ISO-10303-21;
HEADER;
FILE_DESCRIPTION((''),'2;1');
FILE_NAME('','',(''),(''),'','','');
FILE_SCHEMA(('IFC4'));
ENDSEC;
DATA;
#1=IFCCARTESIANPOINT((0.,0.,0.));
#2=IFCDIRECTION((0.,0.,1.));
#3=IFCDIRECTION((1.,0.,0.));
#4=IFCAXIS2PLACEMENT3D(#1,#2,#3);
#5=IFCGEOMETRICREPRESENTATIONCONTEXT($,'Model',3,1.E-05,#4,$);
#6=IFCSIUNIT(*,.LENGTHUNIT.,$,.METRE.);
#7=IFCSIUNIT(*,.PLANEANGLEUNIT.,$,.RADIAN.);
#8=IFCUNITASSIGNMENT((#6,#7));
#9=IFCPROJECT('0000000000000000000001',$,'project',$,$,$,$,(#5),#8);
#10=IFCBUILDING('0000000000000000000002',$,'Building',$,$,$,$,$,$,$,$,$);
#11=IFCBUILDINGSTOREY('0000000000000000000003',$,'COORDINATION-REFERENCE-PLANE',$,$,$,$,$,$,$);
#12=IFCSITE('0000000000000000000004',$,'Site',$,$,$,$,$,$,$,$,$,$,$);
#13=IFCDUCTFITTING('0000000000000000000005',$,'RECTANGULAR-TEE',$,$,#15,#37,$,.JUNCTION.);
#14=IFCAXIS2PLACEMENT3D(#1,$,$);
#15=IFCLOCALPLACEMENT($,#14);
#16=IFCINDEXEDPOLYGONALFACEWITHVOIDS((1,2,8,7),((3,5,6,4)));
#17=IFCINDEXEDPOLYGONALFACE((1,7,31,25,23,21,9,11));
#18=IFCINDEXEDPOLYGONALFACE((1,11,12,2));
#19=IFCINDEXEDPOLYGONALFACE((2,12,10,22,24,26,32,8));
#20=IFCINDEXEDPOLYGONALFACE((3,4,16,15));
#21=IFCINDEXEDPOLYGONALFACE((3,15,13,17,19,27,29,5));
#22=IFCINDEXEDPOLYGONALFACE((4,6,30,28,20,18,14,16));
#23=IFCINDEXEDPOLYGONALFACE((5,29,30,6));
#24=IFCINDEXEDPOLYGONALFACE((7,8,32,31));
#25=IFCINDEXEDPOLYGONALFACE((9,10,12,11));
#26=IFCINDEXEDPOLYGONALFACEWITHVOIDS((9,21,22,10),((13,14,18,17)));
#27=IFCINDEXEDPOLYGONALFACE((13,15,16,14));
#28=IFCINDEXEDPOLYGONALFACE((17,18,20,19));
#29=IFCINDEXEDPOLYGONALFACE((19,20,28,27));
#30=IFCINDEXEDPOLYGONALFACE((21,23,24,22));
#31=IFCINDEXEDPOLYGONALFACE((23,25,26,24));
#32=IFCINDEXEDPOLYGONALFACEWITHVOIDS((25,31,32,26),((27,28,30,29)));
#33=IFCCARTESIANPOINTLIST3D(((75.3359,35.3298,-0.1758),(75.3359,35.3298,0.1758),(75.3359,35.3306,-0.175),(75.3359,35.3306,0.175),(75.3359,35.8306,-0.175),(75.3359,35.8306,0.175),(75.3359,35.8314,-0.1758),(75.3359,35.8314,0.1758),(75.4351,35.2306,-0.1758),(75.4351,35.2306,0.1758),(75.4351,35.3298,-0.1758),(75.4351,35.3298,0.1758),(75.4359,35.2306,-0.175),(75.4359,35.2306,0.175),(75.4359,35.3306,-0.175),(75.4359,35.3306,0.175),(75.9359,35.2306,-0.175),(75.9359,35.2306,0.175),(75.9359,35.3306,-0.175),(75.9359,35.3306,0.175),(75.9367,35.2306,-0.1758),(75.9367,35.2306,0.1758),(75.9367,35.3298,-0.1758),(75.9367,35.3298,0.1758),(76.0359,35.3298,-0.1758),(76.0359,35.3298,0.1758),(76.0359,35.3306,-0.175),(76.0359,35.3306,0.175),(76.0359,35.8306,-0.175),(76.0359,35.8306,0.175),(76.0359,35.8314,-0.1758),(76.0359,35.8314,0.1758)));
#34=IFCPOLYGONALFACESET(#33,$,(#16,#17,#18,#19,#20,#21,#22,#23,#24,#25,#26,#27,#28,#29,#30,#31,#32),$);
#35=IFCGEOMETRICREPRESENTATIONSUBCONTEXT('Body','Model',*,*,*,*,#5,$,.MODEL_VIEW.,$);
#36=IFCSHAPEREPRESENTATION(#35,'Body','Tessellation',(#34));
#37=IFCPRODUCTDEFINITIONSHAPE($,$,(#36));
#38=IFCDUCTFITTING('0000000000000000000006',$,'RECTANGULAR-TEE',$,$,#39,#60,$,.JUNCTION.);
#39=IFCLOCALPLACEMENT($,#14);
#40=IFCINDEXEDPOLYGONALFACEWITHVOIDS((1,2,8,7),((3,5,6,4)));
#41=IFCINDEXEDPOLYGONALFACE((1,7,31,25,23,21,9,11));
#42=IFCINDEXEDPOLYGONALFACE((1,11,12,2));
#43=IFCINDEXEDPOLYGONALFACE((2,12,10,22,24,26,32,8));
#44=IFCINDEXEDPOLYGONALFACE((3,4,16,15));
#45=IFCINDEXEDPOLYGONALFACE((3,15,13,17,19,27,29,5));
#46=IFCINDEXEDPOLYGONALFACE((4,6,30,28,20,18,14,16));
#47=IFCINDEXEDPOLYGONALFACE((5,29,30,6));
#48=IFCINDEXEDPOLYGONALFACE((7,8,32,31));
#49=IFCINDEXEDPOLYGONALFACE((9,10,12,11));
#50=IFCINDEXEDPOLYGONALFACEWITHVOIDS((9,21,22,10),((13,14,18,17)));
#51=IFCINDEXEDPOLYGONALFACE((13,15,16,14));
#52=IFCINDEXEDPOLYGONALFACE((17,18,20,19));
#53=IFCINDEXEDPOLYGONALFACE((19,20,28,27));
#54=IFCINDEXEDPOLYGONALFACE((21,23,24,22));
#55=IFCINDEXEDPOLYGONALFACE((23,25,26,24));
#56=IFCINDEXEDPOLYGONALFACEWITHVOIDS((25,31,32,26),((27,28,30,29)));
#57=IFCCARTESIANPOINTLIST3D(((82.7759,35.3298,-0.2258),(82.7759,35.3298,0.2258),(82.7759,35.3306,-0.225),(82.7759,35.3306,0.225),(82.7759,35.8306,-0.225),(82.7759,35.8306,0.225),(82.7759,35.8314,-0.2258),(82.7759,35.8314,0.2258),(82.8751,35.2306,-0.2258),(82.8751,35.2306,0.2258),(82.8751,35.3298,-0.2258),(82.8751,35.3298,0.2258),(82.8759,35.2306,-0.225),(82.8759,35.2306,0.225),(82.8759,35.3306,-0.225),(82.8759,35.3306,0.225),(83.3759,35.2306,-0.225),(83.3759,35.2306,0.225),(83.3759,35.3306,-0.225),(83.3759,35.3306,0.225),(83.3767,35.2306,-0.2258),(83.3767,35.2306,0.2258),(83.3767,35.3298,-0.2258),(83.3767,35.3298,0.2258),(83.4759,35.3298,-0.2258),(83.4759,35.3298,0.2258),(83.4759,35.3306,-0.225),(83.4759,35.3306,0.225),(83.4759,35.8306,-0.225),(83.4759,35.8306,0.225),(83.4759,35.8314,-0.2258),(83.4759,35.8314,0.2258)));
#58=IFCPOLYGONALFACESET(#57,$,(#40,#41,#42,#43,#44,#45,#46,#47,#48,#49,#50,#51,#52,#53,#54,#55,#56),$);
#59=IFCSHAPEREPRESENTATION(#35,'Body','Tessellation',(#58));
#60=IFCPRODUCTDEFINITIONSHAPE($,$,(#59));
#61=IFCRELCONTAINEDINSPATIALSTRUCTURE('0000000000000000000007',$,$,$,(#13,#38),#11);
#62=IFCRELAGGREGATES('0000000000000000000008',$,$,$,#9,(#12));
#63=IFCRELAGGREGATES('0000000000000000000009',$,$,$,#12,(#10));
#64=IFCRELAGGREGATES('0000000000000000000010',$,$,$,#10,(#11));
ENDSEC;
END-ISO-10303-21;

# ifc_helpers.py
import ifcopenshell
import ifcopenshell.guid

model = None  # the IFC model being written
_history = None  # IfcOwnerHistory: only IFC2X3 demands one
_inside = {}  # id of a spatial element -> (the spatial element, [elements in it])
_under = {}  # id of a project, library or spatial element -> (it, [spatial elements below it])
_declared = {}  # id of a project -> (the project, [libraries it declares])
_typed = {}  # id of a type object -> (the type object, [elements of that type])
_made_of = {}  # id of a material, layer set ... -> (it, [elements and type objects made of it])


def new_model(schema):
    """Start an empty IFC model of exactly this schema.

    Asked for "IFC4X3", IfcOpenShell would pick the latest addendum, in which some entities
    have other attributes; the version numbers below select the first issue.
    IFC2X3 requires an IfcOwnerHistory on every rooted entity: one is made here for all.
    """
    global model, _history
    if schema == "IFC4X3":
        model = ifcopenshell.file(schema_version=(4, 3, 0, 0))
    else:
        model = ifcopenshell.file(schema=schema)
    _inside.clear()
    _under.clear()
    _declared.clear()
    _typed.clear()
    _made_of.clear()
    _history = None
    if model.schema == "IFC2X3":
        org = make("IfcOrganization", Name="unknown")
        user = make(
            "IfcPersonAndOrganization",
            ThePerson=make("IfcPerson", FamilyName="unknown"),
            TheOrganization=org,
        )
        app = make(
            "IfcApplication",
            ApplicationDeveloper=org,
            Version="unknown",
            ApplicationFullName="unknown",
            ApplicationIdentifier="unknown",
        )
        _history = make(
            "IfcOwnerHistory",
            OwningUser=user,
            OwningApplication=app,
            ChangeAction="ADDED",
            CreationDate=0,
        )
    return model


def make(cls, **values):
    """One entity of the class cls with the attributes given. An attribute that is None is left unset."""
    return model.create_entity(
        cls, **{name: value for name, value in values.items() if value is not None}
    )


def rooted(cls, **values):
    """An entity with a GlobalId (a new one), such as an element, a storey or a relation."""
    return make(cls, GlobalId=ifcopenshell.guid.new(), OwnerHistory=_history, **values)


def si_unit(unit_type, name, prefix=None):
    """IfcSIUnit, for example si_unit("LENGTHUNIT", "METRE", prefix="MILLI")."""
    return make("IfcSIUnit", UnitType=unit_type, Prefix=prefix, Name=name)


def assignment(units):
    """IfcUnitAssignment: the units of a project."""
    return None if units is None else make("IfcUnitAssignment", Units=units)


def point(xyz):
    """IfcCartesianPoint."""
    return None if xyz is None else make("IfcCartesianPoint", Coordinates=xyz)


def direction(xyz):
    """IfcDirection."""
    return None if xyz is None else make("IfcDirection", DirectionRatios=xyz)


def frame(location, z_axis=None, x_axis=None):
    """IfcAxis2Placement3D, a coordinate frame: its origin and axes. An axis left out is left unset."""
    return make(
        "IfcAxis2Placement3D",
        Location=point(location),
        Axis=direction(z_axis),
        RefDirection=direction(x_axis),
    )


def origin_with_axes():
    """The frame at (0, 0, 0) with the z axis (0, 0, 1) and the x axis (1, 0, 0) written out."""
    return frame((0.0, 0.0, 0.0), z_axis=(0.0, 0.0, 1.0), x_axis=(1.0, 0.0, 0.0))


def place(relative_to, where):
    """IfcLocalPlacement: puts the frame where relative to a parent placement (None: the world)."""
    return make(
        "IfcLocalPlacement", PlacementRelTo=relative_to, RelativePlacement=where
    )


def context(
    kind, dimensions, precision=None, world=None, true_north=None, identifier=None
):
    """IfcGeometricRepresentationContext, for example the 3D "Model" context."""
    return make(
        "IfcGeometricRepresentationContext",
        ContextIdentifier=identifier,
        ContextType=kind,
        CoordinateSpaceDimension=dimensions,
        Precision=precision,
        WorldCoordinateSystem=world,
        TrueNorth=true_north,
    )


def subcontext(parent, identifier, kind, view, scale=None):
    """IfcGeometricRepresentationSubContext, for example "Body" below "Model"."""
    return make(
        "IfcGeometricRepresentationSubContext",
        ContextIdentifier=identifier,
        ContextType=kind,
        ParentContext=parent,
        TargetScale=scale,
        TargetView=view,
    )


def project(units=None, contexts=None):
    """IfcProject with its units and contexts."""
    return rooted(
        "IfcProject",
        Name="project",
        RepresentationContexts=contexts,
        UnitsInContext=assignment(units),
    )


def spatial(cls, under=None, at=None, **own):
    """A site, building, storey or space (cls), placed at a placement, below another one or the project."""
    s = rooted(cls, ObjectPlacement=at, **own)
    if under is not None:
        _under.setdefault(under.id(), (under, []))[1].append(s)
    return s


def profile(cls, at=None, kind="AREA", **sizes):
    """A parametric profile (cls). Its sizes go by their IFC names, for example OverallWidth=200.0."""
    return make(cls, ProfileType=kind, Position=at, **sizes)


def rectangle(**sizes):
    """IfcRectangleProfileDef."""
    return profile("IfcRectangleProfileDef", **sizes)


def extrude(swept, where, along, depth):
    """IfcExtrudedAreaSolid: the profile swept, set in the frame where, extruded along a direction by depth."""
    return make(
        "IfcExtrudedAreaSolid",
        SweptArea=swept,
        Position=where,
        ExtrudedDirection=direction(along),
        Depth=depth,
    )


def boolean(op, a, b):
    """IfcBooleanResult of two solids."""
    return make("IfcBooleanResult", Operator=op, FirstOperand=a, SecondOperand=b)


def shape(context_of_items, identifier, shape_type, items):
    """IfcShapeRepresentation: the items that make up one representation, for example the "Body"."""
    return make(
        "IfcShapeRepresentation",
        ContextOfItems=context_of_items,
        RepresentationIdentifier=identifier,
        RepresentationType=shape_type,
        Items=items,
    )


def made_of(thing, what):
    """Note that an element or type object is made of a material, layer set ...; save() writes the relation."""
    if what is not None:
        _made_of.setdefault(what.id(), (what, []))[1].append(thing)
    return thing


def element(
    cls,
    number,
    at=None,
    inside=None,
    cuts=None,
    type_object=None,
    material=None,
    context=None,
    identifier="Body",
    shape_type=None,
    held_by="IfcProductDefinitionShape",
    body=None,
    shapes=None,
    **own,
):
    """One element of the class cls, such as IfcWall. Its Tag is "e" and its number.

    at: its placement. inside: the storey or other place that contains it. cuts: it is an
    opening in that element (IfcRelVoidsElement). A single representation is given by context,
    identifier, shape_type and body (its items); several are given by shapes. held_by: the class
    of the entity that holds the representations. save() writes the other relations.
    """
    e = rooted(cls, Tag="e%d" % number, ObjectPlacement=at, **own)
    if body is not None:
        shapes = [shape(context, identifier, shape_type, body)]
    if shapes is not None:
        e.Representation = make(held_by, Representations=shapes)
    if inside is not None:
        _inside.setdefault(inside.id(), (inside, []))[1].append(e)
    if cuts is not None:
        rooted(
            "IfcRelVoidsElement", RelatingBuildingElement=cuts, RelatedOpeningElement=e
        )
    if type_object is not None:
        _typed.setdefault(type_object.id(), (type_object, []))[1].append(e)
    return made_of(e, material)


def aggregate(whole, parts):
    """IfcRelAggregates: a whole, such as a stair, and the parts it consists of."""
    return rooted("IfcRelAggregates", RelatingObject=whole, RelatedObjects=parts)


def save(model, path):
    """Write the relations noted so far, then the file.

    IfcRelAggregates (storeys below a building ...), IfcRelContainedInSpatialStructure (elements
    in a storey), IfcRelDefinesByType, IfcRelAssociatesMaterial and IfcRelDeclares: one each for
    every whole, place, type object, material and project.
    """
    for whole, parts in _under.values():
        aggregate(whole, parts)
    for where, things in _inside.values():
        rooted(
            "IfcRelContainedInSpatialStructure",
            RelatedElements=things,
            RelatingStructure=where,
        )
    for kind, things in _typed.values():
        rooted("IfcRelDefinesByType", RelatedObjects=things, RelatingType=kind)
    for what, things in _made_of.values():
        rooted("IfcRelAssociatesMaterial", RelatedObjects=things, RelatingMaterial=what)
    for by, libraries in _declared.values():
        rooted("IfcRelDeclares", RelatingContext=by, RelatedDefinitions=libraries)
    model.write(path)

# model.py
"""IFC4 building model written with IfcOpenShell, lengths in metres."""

from ifc_helpers import new_model, si_unit, frame, origin_with_axes, place, context, subcontext, project, spatial, rectangle, extrude, boolean, element, save


model = new_model("IFC4")

# Units and contexts
model_context = context("Model", 3, precision=1e-05, world=origin_with_axes())
body_context = subcontext(model_context, "Body", "Model", "MODEL_VIEW")
ifc_project = project(units=[si_unit("LENGTHUNIT", "METRE"), si_unit("PLANEANGLEUNIT", "RADIAN")], contexts=[model_context])

# Site, building, storey
site = spatial("IfcSite", under=ifc_project, Name="Site")
building = spatial("IfcBuilding", under=site, Name="Building")
storey = spatial("IfcBuildingStorey", under=building, Name="COORDINATION-REFERENCE-PLANE")

# Duct fittings
duct_fitting_1_placement = place(None, frame((75.6859, 35.5806, 0.0), z_axis=(-1.0, 0.0, 0.0), x_axis=(0.0, -1.0, 0.0)))
solid_1 = boolean("UNION", extrude(rectangle(XDim=0.5, YDim=0.35), frame((0.0, 0.0, -0.35), z_axis=(0.0, 0.0, 1.0), x_axis=(1.0, 0.0, 0.0)), (0.0, 0.0, 1.0), 0.7), extrude(rectangle(XDim=0.5, YDim=0.35), frame((0.0, 0.0, 0.0), z_axis=(1.0, 0.0, 0.0), x_axis=(0.0, 0.0, -1.0)), (0.0, 0.0, 1.0), 0.35))
element("IfcDuctFitting", 1, at=duct_fitting_1_placement, inside=storey, Name="RECTANGULAR-TEE", PredefinedType="JUNCTION", context=body_context, shape_type="CSG", body=[
    boolean("DIFFERENCE", boolean("UNION", extrude(rectangle(XDim=0.5016, YDim=0.3516), frame((0.0, 0.0, -0.35), z_axis=(0.0, 0.0, 1.0), x_axis=(1.0, 0.0, 0.0)), (0.0, 0.0, 1.0), 0.7), extrude(rectangle(XDim=0.5016, YDim=0.3516), frame((0.0, 0.0, 0.0), z_axis=(1.0, 0.0, 0.0), x_axis=(0.0, 0.0, -1.0)), (0.0, 0.0, 1.0), 0.35)), solid_1),
])
duct_fitting_2_placement = place(None, frame((83.1259, 35.5806, 0.0), z_axis=(-1.0, 0.0, 0.0), x_axis=(0.0, -1.0, 0.0)))
solid_2 = boolean("UNION", extrude(rectangle(XDim=0.5, YDim=0.45), frame((0.0, 0.0, -0.35), z_axis=(0.0, 0.0, 1.0), x_axis=(1.0, 0.0, 0.0)), (0.0, 0.0, 1.0), 0.7), extrude(rectangle(XDim=0.5, YDim=0.45), frame((0.0, 0.0, 0.0), z_axis=(1.0, 0.0, 0.0), x_axis=(0.0, 0.0, -1.0)), (0.0, 0.0, 1.0), 0.35))
element("IfcDuctFitting", 2, at=duct_fitting_2_placement, inside=storey, Name="RECTANGULAR-TEE", PredefinedType="JUNCTION", context=body_context, shape_type="CSG", body=[
    boolean("DIFFERENCE", boolean("UNION", extrude(rectangle(XDim=0.5016, YDim=0.4516), frame((0.0, 0.0, -0.35), z_axis=(0.0, 0.0, 1.0), x_axis=(1.0, 0.0, 0.0)), (0.0, 0.0, 1.0), 0.7), extrude(rectangle(XDim=0.5016, YDim=0.4516), frame((0.0, 0.0, 0.0), z_axis=(1.0, 0.0, 0.0), x_axis=(0.0, 0.0, -1.0)), (0.0, 0.0, 1.0), 0.35)), solid_2),
])

save(model, "model.ifc")
